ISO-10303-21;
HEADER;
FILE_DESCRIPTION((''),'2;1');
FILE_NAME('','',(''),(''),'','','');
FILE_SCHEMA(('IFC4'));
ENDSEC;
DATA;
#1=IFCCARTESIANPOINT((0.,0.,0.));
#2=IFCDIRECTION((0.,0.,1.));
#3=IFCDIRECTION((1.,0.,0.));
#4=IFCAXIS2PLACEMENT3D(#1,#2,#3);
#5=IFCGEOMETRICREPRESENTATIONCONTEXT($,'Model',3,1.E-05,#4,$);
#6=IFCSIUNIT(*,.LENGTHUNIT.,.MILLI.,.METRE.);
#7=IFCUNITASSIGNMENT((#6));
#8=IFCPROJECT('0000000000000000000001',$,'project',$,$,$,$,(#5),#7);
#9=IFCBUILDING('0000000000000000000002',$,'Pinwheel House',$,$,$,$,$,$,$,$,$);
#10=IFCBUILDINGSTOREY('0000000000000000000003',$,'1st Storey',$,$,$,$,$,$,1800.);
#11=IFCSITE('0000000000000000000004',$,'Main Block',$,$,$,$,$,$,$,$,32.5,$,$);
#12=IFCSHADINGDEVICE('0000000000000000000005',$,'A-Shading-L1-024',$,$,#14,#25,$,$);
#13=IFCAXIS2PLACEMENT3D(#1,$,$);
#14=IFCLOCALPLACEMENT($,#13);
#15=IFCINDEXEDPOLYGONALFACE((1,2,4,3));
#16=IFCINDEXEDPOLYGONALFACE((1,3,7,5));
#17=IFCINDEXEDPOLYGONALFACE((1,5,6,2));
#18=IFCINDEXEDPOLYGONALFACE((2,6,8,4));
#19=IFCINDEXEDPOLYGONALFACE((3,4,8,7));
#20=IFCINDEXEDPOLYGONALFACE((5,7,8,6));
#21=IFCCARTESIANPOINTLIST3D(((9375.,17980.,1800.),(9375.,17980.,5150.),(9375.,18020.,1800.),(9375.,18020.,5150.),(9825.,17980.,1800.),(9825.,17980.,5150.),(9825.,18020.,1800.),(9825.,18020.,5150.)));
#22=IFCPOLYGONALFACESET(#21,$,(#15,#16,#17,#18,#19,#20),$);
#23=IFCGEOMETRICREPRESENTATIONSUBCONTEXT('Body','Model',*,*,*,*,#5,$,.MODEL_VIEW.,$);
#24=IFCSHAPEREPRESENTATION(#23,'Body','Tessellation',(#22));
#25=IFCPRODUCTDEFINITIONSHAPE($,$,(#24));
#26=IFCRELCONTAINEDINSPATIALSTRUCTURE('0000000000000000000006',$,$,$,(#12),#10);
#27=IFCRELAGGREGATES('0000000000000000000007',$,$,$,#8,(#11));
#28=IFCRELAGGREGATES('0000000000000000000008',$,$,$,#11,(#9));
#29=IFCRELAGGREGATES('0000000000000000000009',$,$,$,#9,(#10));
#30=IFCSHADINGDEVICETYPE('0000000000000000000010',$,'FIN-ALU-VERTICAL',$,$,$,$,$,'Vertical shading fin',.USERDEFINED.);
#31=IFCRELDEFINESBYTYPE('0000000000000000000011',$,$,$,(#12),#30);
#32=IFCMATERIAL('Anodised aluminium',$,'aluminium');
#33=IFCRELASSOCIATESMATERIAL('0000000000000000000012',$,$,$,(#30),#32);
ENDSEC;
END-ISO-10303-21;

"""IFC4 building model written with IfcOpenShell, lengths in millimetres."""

from ifc_helpers import new_model, si_unit, frame, origin_with_axes, place, context, subcontext, project, spatial, indexed_curve, outline, extrude, material, type_object, element, save


model = new_model("IFC4")

# Units and contexts
model_context = context("Model", 3, precision=1e-05, world=origin_with_axes())
body_context = subcontext(model_context, "Body", "Model", "MODEL_VIEW")
ifc_project = project(units=[si_unit("LENGTHUNIT", "METRE", prefix="MILLI")], contexts=[model_context])

# Site, building, storey
site = spatial("IfcSite", under=ifc_project, Name="Main Block", RefElevation=32.5)
building = spatial("IfcBuilding", under=site, Name="Pinwheel House")
storey = spatial("IfcBuildingStorey", under=building, Name="1st Storey", Elevation=1800.0)

# Shared definitions
ifc_material_1 = material(Name="Anodised aluminium", Category="aluminium")

# Shading device
shading_device_type = type_object("IfcShadingDeviceType", Name="FIN-ALU-VERTICAL", ElementType="Vertical shading fin", PredefinedType="USERDEFINED", material=ifc_material_1)
for number, where, z_axis, x_axis, name in (
    (1, (9600.0, 18000.0, 1800.0), (0.0, 0.0, 1.0), (0.0, -1.0, 0.0), "A-Shading-L1-024"),
):
    element("IfcShadingDevice", number, at=place(None, frame(where, z_axis=z_axis, x_axis=x_axis)), inside=storey, type_object=shading_device_type, Name=name, context=body_context, shape_type="SweptSolid", body=[
        extrude(outline(indexed_curve([(-20.0, -225.0), (20.0, -225.0), (20.0, 225.0), (-20.0, 225.0)])), None, (0.0, 0.0, 1.0), 3350.0),
    ])

save(model, "model.ifc")
